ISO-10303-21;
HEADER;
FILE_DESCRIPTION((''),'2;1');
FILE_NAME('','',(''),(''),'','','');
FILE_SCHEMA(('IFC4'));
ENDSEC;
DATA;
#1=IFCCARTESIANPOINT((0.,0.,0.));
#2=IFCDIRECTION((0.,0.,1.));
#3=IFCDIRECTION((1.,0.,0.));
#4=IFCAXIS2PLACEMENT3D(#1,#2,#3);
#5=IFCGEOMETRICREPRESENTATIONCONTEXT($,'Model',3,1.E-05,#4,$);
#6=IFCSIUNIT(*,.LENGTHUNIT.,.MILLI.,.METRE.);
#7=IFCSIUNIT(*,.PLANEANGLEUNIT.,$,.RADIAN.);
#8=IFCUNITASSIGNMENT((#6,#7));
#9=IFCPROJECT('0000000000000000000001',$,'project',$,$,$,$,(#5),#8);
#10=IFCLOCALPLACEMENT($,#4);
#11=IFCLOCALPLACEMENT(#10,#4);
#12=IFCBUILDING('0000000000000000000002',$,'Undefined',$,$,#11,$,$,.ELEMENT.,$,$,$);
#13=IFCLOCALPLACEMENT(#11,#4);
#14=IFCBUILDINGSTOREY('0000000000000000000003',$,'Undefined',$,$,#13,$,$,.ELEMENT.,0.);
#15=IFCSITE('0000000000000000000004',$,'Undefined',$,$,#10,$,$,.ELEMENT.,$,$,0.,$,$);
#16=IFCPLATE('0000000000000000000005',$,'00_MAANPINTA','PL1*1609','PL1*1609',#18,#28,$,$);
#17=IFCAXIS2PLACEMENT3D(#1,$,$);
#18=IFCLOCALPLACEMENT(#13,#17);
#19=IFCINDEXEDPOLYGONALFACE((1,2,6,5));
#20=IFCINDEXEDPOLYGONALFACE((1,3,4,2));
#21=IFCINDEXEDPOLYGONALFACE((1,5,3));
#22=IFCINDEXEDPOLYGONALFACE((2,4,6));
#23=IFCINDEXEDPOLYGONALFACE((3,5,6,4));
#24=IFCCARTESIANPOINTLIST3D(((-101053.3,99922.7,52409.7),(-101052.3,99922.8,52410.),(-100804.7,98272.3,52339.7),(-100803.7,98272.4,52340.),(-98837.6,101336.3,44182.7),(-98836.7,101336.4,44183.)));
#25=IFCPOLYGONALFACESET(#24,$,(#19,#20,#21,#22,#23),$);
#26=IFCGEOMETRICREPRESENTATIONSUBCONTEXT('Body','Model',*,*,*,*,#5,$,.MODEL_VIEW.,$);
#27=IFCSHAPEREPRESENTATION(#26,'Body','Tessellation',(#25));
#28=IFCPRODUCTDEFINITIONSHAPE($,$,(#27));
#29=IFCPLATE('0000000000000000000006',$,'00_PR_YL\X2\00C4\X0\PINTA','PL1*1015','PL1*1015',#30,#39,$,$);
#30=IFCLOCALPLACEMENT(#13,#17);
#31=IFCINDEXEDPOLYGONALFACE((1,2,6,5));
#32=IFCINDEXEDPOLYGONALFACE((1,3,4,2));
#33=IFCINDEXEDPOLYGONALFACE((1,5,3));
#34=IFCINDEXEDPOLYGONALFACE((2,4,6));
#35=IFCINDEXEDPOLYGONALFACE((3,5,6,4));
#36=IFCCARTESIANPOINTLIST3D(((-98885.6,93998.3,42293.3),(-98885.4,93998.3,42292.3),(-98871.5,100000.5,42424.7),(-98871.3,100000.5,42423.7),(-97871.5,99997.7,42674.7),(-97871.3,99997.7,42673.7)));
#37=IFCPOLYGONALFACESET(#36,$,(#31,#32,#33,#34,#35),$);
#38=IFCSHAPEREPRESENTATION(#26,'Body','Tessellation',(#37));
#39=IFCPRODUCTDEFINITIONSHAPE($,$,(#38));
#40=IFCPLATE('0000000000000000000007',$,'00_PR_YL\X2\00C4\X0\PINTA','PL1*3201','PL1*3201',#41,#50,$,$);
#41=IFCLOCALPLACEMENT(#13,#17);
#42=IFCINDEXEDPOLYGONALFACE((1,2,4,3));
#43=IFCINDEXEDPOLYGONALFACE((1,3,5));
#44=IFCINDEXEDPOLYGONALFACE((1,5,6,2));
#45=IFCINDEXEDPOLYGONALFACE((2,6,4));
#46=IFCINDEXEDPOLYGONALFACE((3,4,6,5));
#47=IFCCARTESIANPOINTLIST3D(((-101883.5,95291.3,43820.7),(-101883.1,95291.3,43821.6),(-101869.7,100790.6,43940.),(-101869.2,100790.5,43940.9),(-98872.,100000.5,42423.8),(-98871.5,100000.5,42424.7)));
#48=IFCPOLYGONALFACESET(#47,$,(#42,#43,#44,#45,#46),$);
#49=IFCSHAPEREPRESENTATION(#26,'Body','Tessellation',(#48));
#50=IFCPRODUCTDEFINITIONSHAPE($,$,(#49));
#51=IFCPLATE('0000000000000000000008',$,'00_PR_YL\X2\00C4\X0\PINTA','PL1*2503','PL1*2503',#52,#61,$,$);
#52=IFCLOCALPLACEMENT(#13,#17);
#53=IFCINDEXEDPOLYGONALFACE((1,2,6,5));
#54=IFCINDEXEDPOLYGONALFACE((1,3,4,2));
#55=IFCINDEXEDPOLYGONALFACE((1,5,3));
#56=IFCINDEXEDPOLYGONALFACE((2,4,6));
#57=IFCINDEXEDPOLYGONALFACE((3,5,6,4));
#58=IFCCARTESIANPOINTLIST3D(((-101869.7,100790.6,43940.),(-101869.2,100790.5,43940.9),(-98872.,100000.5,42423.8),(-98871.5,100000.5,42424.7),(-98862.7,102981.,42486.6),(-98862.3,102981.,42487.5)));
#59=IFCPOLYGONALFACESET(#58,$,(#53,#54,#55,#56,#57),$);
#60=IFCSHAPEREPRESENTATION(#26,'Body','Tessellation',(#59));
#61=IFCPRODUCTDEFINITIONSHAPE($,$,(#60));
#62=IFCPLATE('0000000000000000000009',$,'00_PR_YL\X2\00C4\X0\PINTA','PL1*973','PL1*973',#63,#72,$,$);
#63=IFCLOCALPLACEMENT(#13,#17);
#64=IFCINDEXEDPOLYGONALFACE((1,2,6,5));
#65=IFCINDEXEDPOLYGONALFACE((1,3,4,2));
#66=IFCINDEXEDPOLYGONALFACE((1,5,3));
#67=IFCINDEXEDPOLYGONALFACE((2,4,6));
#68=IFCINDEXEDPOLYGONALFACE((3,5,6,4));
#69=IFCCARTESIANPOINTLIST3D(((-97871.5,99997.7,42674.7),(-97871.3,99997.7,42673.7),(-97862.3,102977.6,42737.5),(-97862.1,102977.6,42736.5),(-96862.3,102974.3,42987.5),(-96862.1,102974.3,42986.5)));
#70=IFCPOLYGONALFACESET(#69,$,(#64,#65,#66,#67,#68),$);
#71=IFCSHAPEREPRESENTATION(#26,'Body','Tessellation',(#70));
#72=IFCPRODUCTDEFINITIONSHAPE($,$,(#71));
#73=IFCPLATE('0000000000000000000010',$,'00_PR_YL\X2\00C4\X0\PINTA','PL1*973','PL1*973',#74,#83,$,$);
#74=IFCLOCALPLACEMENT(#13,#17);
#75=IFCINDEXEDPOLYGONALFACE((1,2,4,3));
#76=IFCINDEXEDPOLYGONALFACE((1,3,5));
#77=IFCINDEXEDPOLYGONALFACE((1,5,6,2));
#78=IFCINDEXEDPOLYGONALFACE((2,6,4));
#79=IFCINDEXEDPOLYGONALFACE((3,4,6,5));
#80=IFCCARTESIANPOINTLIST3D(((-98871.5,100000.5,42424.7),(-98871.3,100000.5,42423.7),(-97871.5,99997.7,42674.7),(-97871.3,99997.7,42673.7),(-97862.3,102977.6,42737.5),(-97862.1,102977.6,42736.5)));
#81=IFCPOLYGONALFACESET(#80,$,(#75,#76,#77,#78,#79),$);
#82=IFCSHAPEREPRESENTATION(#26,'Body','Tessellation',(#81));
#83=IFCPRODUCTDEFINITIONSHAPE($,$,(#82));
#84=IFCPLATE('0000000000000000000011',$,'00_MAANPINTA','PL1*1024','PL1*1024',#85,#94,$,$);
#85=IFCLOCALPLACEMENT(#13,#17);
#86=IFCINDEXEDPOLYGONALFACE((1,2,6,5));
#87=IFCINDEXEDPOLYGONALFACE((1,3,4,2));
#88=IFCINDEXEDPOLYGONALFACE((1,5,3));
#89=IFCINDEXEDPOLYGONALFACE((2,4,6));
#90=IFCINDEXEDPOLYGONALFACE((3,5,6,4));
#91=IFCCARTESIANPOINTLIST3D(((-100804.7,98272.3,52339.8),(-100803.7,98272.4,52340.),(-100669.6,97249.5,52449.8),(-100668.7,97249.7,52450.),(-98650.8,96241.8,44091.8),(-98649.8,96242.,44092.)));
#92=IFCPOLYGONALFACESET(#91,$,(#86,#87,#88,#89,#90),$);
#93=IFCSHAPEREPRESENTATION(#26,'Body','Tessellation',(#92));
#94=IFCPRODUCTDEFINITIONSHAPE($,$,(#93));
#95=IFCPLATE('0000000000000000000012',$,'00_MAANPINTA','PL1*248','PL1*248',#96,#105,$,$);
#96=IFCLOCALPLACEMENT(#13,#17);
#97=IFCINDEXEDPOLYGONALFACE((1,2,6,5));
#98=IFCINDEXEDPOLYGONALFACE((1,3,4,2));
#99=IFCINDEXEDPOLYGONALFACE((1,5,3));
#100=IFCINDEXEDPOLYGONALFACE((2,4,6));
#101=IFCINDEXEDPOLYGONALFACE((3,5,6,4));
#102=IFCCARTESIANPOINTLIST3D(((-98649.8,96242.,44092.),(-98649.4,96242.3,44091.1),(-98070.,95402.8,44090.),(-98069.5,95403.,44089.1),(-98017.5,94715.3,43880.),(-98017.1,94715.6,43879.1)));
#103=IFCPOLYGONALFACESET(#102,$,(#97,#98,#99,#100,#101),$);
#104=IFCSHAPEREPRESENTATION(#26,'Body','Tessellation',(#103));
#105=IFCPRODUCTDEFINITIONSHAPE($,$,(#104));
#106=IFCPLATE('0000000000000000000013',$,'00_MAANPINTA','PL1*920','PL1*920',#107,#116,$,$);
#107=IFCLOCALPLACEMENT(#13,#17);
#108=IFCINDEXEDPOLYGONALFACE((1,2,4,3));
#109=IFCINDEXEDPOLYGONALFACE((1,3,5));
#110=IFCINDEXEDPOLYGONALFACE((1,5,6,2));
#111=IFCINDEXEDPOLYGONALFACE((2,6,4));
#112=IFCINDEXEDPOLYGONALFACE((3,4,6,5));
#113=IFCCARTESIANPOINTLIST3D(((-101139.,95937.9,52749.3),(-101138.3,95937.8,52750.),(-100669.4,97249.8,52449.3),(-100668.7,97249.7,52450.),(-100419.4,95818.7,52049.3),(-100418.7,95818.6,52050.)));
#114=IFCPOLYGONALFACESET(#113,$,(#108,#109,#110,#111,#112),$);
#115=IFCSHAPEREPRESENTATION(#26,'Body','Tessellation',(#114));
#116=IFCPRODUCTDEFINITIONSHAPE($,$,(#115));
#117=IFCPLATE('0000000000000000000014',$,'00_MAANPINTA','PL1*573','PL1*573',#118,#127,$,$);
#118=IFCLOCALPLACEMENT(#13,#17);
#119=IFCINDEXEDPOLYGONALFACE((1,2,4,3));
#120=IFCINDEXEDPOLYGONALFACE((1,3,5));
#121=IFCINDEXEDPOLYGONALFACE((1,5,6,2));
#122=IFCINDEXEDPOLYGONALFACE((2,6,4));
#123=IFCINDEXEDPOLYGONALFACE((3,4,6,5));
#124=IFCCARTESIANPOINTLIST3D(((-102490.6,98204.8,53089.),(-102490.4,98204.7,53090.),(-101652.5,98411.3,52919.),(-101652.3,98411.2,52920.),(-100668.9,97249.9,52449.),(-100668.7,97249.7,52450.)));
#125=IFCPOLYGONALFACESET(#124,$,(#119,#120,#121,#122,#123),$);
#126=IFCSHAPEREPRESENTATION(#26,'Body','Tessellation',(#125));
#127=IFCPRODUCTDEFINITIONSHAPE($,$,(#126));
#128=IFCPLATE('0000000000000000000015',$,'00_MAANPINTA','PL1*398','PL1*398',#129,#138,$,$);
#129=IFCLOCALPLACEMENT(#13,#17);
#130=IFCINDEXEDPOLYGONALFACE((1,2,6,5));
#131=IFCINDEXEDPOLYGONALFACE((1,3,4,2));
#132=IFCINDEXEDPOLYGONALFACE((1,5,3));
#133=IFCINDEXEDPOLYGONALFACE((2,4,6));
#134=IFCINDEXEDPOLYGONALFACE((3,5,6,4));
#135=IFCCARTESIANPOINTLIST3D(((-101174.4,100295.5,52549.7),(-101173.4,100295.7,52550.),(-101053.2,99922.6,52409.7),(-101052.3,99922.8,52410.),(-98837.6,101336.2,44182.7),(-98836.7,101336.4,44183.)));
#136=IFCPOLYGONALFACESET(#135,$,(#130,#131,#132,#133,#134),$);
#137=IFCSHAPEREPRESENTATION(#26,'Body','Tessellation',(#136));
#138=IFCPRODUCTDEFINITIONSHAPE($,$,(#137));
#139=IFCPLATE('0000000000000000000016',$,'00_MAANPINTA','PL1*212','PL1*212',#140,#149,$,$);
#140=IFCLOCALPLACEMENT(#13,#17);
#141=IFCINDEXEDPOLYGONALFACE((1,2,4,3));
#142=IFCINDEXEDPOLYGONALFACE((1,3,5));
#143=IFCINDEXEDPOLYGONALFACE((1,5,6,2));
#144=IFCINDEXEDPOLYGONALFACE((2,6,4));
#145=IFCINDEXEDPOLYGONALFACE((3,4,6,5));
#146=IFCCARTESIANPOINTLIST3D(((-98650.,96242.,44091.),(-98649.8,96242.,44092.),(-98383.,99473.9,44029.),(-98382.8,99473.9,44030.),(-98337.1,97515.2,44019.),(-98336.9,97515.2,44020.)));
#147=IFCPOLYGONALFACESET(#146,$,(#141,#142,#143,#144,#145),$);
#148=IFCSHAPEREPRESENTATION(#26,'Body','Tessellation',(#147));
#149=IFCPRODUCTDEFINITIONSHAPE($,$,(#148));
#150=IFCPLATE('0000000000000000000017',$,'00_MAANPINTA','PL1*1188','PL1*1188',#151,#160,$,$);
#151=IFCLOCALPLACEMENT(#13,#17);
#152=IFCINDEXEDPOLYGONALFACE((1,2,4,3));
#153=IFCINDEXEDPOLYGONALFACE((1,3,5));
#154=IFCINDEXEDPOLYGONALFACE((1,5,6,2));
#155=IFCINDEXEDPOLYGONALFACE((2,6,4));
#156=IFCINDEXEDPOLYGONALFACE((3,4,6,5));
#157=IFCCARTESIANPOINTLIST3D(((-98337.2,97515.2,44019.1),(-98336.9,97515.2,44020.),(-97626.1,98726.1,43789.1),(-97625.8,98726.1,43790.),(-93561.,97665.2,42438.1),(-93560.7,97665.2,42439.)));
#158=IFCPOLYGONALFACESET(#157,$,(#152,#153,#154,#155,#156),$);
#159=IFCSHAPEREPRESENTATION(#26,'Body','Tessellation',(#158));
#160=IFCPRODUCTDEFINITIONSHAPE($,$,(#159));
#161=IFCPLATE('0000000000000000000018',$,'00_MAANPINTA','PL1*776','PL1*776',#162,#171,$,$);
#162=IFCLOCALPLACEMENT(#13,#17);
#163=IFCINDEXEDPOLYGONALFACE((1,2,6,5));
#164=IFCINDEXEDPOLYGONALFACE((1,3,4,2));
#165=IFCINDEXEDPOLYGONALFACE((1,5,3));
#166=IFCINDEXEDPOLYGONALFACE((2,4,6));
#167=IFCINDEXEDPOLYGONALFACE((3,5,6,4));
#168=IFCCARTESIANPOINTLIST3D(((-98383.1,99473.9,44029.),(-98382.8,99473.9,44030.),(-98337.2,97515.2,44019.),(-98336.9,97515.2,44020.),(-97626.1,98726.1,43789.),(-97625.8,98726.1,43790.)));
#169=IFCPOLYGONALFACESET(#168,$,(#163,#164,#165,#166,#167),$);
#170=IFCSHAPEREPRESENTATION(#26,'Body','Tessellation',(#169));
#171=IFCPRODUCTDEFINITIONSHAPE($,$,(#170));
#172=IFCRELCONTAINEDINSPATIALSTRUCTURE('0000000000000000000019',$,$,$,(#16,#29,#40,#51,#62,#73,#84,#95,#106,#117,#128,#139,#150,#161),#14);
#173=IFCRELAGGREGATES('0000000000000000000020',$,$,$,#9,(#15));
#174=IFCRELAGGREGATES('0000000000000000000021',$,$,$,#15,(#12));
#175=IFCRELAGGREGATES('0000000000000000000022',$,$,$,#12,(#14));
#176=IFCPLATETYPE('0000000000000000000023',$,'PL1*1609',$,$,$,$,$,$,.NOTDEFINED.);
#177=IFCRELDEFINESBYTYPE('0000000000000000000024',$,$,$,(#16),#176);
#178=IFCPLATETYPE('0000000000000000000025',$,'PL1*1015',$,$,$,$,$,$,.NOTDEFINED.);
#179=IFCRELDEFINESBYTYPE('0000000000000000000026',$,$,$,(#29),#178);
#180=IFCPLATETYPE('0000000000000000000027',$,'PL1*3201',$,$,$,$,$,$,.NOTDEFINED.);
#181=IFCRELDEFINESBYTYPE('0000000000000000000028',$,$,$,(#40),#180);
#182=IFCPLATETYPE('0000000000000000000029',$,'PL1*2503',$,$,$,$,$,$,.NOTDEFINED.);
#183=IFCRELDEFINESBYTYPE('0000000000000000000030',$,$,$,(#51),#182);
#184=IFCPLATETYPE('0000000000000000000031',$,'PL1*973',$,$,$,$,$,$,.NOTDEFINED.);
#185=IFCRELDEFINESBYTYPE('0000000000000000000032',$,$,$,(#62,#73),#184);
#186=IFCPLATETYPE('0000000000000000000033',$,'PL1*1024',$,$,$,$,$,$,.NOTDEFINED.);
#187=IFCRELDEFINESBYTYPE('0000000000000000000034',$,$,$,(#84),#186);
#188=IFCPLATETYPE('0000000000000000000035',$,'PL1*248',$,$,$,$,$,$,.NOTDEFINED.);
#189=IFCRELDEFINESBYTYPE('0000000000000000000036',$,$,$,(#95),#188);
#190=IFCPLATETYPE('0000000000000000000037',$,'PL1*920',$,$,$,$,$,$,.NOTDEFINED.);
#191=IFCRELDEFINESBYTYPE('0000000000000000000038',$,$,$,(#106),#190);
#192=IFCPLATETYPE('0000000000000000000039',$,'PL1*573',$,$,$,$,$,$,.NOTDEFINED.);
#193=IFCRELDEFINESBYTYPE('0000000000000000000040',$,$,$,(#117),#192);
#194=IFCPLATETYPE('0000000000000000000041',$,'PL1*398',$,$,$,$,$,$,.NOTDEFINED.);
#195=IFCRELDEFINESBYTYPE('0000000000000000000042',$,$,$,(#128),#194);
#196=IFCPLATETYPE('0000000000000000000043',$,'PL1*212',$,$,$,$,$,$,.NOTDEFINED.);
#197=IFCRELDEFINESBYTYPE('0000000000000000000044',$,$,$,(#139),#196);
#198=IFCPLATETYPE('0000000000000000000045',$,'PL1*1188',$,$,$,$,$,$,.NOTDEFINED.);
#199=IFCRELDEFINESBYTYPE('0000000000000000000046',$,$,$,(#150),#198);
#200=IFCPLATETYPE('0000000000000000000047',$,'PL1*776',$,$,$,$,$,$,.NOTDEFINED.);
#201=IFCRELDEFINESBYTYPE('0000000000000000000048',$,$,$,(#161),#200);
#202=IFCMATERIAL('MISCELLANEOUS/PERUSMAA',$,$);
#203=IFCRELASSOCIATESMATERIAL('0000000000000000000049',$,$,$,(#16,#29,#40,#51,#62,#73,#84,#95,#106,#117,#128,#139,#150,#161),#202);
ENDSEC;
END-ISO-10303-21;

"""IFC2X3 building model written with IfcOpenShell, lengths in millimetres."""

from ifc_helpers import new_model, si_unit, frame, origin_with_axes, place, context, subcontext, project, spatial, polyline, outline, extrude, material, type_object, element, save


model = new_model("IFC2X3")

# Units and contexts
model_context = context("Model", 3, precision=1e-05, world=origin_with_axes())
body_context = subcontext(model_context, "Body", "Model", "MODEL_VIEW")
ifc_project = project(units=[si_unit("LENGTHUNIT", "METRE", prefix="MILLI"), si_unit("PLANEANGLEUNIT", "RADIAN")], contexts=[model_context])

# Site, building, storey
site_placement = place(None, origin_with_axes())
site = spatial("IfcSite", under=ifc_project, at=site_placement, Name="Undefined", CompositionType="ELEMENT", RefElevation=0.0)
building_placement = place(site_placement, origin_with_axes())
building = spatial("IfcBuilding", under=site, at=building_placement, Name="Undefined", CompositionType="ELEMENT")
storey_placement = place(building_placement, origin_with_axes())
storey = spatial("IfcBuildingStorey", under=building, at=storey_placement, Name="Undefined", CompositionType="ELEMENT", Elevation=0.0)

# Plates
ifc_material = material(Name="MISCELLANEOUS/PERUSMAA")
plate_type_1 = type_object("IfcPlateType", Name="PL1*1609", PredefinedType="NOTDEFINED")
plate_1_placement = place(storey_placement, frame((-101052.8, 99922.8, 52409.9), z_axis=(-0.951314, -0.13145, -0.278786), x_axis=(0.256539, 0.163674, -0.952575)))
element("IfcPlate", 1, at=plate_1_placement, inside=storey, type_object=plate_type_1, material=ifc_material, Name="00_MAANPINTA", Description="PL1*1609", ObjectType="PL1*1609", context=body_context, shape_type="SweptSolid", body=[
    extrude(outline(polyline([(0.0, 0.0), (8636.6, 0.0), (-139.7, 1664.7), (0.0, 0.0)])), frame((0.0, 0.0, -0.5), z_axis=(0.0, 0.0, 1.0), x_axis=(1.0, 0.0, 0.0)), (0.0, 0.0, 1.0), 1.0),
])
plate_type_2 = type_object("IfcPlateType", Name="PL1*1015", PredefinedType="NOTDEFINED")
plate_2_placement = place(storey_placement, frame((-97871.4, 99997.7, 42674.2), z_axis=(0.24254, 0.02066, -0.969921), x_axis=(-0.166339, -0.984082, -0.062557)))
element("IfcPlate", 2, at=plate_2_placement, inside=storey, type_object=plate_type_2, material=ifc_material, Name="00_PR_YLÄPINTA", Description="PL1*1015", ObjectType="PL1*1015", context=body_context, shape_type="SweptSolid", body=[
    extrude(outline(polyline([(0.0, 0.0), (6096.4, 0.0), (179.2, 1015.1), (0.0, 0.0)])), frame((0.0, 0.0, -0.5), z_axis=(0.0, 0.0, 1.0), x_axis=(1.0, 0.0, 0.0)), (0.0, 0.0, 1.0), 1.0),
])
plate_type_3 = type_object("IfcPlateType", Name="PL1*3201", PredefinedType="NOTDEFINED")
plate_3_placement = place(storey_placement, frame((-98871.7, 100000.5, 42424.2), z_axis=(-0.446934, 0.020526, -0.894331), x_axis=(-0.522684, -0.817325, 0.242448)))
element("IfcPlate", 3, at=plate_3_placement, inside=storey, type_object=plate_type_3, material=ifc_material, Name="00_PR_YLÄPINTA", Description="PL1*3201", ObjectType="PL1*3201", context=body_context, shape_type="SweptSolid", body=[
    extrude(outline(polyline([(0.0, 0.0), (5761.7, 0.0), (1288.7, 3201.3), (0.0, 0.0)])), frame((0.0, 0.0, -0.5), z_axis=(0.0, 0.0, 1.0), x_axis=(1.0, 0.0, 0.0)), (0.0, 0.0, 1.0), 1.0),
])
plate_type_4 = type_object("IfcPlateType", Name="PL1*2503", PredefinedType="NOTDEFINED")
plate_4_placement = place(storey_placement, frame((-101869.5, 100790.6, 43940.4), z_axis=(-0.447, 0.020227, -0.894305), x_axis=(0.752863, 0.548429, -0.363899)))
element("IfcPlate", 4, at=plate_4_placement, inside=storey, type_object=plate_type_4, material=ifc_material, Name="00_PR_YLÄPINTA", Description="PL1*2503", ObjectType="PL1*2503", context=body_context, shape_type="SweptSolid", body=[
    extrude(outline(polyline([(0.0, 0.0), (3994.0, 0.0), (2375.3, 2503.4), (0.0, 0.0)])), frame((0.0, 0.0, -0.5), z_axis=(0.0, 0.0, 1.0), x_axis=(1.0, 0.0, 0.0)), (0.0, 0.0, 1.0), 1.0),
])
plate_type_5 = type_object("IfcPlateType", Name="PL1*973", PredefinedType="NOTDEFINED")
plate_5_placement = place(storey_placement, frame((-97871.4, 99997.7, 42674.2), z_axis=(0.242552, 0.019692, -0.969939), x_axis=(0.003091, 0.999773, 0.021071)))
element("IfcPlate", 5, at=plate_5_placement, inside=storey, type_object=plate_type_5, material=ifc_material, Name="00_PR_YLÄPINTA", Description="PL1*973", ObjectType="PL1*973", context=body_context, shape_type="SweptSolid", body=[
    extrude(outline(polyline([(0.0, 0.0), (2980.6, 0.0), (2985.7, 1030.8), (0.0, 0.0)])), frame((0.0, 0.0, -0.5), z_axis=(0.0, 0.0, 1.0), x_axis=(1.0, 0.0, 0.0)), (0.0, 0.0, 1.0), 1.0),
])
plate_6_placement = place(storey_placement, frame((-98871.4, 100000.5, 42424.2), z_axis=(0.242542, 0.019692, -0.969941), x_axis=(0.319466, 0.94241, 0.099018)))
element("IfcPlate", 6, at=plate_6_placement, inside=storey, type_object=plate_type_5, material=ifc_material, Name="00_PR_YLÄPINTA", Description="PL1*973", ObjectType="PL1*973", context=body_context, shape_type="SweptSolid", body=[
    extrude(outline(polyline([(0.0, 0.0), (3159.1, 0.0), (341.5, 972.5), (0.0, 0.0)])), frame((0.0, 0.0, -0.5), z_axis=(0.0, 0.0, 1.0), x_axis=(1.0, 0.0, 0.0)), (0.0, 0.0, 1.0), 1.0),
])
plate_type_6 = type_object("IfcPlateType", Name="PL1*1024", PredefinedType="NOTDEFINED")
plate_7_placement = place(storey_placement, frame((-100804.2, 98272.3, 52339.9), z_axis=(-0.964955, -0.150553, -0.214932), x_axis=(0.245796, -0.231706, -0.941221)))
element("IfcPlate", 7, at=plate_7_placement, inside=storey, type_object=plate_type_6, material=ifc_material, Name="00_MAANPINTA", Description="PL1*1024", ObjectType="PL1*1024", context=body_context, shape_type="SweptSolid", body=[
    extrude(outline(polyline([(0.0, 0.0), (8763.1, 0.0), (166.6, 1024.0), (0.0, 0.0)])), frame((0.0, 0.0, -0.5), z_axis=(0.0, 0.0, 1.0), x_axis=(1.0, 0.0, 0.0)), (0.0, 0.0, 1.0), 1.0),
])
plate_type_7 = type_object("IfcPlateType", Name="PL1*248", PredefinedType="NOTDEFINED")
plate_8_placement = place(storey_placement, frame((-98649.6, 96242.1, 44091.6), z_axis=(0.422697, 0.294102, -0.857223), x_axis=(0.568448, -0.822717, -0.001961)))
element("IfcPlate", 8, at=plate_8_placement, inside=storey, type_object=plate_type_7, material=ifc_material, Name="00_MAANPINTA", Description="PL1*248", ObjectType="PL1*248", context=body_context, shape_type="SweptSolid", body=[
    extrude(outline(polyline([(0.0, 0.0), (1020.0, 0.0), (1615.9, 405.5), (0.0, 0.0)])), frame((0.0, 0.0, -0.5), z_axis=(0.0, 0.0, 1.0), x_axis=(1.0, 0.0, 0.0)), (0.0, 0.0, 1.0), 1.0),
])
plate_type_8 = type_object("IfcPlateType", Name="PL1*920", PredefinedType="NOTDEFINED")
plate_9_placement = place(storey_placement, frame((-100669.0, 97249.7, 52449.6), z_axis=(-0.687983, 0.081374, -0.72115), x_axis=(0.165917, -0.94974, -0.265454)))
element("IfcPlate", 9, at=plate_9_placement, inside=storey, type_object=plate_type_8, material=ifc_material, Name="00_MAANPINTA", Description="PL1*920", ObjectType="PL1*920", context=body_context, shape_type="SweptSolid", body=[
    extrude(outline(polyline([(0.0, 0.0), (1506.9, 0.0), (1088.4, 920.3), (0.0, 0.0)])), frame((0.0, 0.0, -0.5), z_axis=(0.0, 0.0, 1.0), x_axis=(1.0, 0.0, 0.0)), (0.0, 0.0, 1.0), 1.0),
])
plate_type_9 = type_object("IfcPlateType", Name="PL1*573", PredefinedType="NOTDEFINED")
plate_10_placement = place(storey_placement, frame((-100668.8, 97249.8, 52449.5), z_axis=(-0.238696, 0.183722, -0.953557), x_axis=(-0.845689, 0.443323, 0.297109)))
element("IfcPlate", 10, at=plate_10_placement, inside=storey, type_object=plate_type_9, material=ifc_material, Name="00_MAANPINTA", Description="PL1*573", ObjectType="PL1*573", context=body_context, shape_type="SweptSolid", body=[
    extrude(outline(polyline([(0.0, 0.0), (2154.1, 0.0), (1486.4, 572.8), (0.0, 0.0)])), frame((0.0, 0.0, -0.5), z_axis=(0.0, 0.0, 1.0), x_axis=(1.0, 0.0, 0.0)), (0.0, 0.0, 1.0), 1.0),
])
plate_type_10 = type_object("IfcPlateType", Name="PL1*398", PredefinedType="NOTDEFINED")
plate_11_placement = place(storey_placement, frame((-101052.8, 99922.7, 52409.9), z_axis=(-0.937642, -0.197027, -0.286371), x_axis=(-0.290924, 0.895692, 0.336301)))
element("IfcPlate", 11, at=plate_11_placement, inside=storey, type_object=plate_type_10, material=ifc_material, Name="00_MAANPINTA", Description="PL1*398", ObjectType="PL1*398", context=body_context, shape_type="SweptSolid", body=[
    extrude(outline(polyline([(0.0, 0.0), (416.3, 0.0), (-2145.2, 8365.9), (0.0, 0.0)])), frame((0.0, 0.0, -0.5), z_axis=(0.0, 0.0, 1.0), x_axis=(1.0, 0.0, 0.0)), (0.0, 0.0, 1.0), 1.0),
])
plate_type_11 = type_object("IfcPlateType", Name="PL1*212", PredefinedType="NOTDEFINED")
plate_12_placement = place(storey_placement, frame((-98649.9, 96242.0, 44091.5), z_axis=(-0.223261, -0.000256, -0.974759), x_axis=(0.082313, 0.996423, -0.019115)))
element("IfcPlate", 12, at=plate_12_placement, inside=storey, type_object=plate_type_11, material=ifc_material, Name="00_MAANPINTA", Description="PL1*212", ObjectType="PL1*212", context=body_context, shape_type="SweptSolid", body=[
    extrude(outline(polyline([(0.0, 0.0), (3243.5, 0.0), (1295.8, 212.3), (0.0, 0.0)])), frame((0.0, 0.0, -0.5), z_axis=(0.0, 0.0, 1.0), x_axis=(1.0, 0.0, 0.0)), (0.0, 0.0, 1.0), 1.0),
])
plate_type_12 = type_object("IfcPlateType", Name="PL1*1188", PredefinedType="NOTDEFINED")
plate_13_placement = place(storey_placement, frame((-98337.1, 97515.2, 44019.5), z_axis=(-0.314367, 0.004299, -0.949292), x_axis=(0.499716, 0.850976, -0.161632)))
element("IfcPlate", 13, at=plate_13_placement, inside=storey, type_object=plate_type_12, material=ifc_material, Name="00_MAANPINTA", Description="PL1*1188", ObjectType="PL1*1188", context=body_context, shape_type="SweptSolid", body=[
    extrude(outline(polyline([(0.0, 0.0), (1423.0, 0.0), (2769.9, 4202.5), (0.0, 0.0)])), frame((0.0, 0.0, -0.5), z_axis=(0.0, 0.0, 1.0), x_axis=(1.0, 0.0, 0.0)), (0.0, 0.0, 1.0), 1.0),
])
plate_type_13 = type_object("IfcPlateType", Name="PL1*776", PredefinedType="NOTDEFINED")
plate_14_placement = place(storey_placement, frame((-98383.0, 99473.9, 44029.5), z_axis=(-0.304251, -0.002267, -0.952589), x_axis=(0.693996, -0.685535, -0.220026)))
element("IfcPlate", 14, at=plate_14_placement, inside=storey, type_object=plate_type_13, material=ifc_material, Name="00_MAANPINTA", Description="PL1*776", ObjectType="PL1*776", context=body_context, shape_type="SweptSolid", body=[
    extrude(outline(polyline([(0.0, 0.0), (1090.8, 0.0), (1376.8, 1393.9), (0.0, 0.0)])), frame((0.0, 0.0, -0.5), z_axis=(0.0, 0.0, 1.0), x_axis=(1.0, 0.0, 0.0)), (0.0, 0.0, 1.0), 1.0),
])

save(model, "model.ifc")
